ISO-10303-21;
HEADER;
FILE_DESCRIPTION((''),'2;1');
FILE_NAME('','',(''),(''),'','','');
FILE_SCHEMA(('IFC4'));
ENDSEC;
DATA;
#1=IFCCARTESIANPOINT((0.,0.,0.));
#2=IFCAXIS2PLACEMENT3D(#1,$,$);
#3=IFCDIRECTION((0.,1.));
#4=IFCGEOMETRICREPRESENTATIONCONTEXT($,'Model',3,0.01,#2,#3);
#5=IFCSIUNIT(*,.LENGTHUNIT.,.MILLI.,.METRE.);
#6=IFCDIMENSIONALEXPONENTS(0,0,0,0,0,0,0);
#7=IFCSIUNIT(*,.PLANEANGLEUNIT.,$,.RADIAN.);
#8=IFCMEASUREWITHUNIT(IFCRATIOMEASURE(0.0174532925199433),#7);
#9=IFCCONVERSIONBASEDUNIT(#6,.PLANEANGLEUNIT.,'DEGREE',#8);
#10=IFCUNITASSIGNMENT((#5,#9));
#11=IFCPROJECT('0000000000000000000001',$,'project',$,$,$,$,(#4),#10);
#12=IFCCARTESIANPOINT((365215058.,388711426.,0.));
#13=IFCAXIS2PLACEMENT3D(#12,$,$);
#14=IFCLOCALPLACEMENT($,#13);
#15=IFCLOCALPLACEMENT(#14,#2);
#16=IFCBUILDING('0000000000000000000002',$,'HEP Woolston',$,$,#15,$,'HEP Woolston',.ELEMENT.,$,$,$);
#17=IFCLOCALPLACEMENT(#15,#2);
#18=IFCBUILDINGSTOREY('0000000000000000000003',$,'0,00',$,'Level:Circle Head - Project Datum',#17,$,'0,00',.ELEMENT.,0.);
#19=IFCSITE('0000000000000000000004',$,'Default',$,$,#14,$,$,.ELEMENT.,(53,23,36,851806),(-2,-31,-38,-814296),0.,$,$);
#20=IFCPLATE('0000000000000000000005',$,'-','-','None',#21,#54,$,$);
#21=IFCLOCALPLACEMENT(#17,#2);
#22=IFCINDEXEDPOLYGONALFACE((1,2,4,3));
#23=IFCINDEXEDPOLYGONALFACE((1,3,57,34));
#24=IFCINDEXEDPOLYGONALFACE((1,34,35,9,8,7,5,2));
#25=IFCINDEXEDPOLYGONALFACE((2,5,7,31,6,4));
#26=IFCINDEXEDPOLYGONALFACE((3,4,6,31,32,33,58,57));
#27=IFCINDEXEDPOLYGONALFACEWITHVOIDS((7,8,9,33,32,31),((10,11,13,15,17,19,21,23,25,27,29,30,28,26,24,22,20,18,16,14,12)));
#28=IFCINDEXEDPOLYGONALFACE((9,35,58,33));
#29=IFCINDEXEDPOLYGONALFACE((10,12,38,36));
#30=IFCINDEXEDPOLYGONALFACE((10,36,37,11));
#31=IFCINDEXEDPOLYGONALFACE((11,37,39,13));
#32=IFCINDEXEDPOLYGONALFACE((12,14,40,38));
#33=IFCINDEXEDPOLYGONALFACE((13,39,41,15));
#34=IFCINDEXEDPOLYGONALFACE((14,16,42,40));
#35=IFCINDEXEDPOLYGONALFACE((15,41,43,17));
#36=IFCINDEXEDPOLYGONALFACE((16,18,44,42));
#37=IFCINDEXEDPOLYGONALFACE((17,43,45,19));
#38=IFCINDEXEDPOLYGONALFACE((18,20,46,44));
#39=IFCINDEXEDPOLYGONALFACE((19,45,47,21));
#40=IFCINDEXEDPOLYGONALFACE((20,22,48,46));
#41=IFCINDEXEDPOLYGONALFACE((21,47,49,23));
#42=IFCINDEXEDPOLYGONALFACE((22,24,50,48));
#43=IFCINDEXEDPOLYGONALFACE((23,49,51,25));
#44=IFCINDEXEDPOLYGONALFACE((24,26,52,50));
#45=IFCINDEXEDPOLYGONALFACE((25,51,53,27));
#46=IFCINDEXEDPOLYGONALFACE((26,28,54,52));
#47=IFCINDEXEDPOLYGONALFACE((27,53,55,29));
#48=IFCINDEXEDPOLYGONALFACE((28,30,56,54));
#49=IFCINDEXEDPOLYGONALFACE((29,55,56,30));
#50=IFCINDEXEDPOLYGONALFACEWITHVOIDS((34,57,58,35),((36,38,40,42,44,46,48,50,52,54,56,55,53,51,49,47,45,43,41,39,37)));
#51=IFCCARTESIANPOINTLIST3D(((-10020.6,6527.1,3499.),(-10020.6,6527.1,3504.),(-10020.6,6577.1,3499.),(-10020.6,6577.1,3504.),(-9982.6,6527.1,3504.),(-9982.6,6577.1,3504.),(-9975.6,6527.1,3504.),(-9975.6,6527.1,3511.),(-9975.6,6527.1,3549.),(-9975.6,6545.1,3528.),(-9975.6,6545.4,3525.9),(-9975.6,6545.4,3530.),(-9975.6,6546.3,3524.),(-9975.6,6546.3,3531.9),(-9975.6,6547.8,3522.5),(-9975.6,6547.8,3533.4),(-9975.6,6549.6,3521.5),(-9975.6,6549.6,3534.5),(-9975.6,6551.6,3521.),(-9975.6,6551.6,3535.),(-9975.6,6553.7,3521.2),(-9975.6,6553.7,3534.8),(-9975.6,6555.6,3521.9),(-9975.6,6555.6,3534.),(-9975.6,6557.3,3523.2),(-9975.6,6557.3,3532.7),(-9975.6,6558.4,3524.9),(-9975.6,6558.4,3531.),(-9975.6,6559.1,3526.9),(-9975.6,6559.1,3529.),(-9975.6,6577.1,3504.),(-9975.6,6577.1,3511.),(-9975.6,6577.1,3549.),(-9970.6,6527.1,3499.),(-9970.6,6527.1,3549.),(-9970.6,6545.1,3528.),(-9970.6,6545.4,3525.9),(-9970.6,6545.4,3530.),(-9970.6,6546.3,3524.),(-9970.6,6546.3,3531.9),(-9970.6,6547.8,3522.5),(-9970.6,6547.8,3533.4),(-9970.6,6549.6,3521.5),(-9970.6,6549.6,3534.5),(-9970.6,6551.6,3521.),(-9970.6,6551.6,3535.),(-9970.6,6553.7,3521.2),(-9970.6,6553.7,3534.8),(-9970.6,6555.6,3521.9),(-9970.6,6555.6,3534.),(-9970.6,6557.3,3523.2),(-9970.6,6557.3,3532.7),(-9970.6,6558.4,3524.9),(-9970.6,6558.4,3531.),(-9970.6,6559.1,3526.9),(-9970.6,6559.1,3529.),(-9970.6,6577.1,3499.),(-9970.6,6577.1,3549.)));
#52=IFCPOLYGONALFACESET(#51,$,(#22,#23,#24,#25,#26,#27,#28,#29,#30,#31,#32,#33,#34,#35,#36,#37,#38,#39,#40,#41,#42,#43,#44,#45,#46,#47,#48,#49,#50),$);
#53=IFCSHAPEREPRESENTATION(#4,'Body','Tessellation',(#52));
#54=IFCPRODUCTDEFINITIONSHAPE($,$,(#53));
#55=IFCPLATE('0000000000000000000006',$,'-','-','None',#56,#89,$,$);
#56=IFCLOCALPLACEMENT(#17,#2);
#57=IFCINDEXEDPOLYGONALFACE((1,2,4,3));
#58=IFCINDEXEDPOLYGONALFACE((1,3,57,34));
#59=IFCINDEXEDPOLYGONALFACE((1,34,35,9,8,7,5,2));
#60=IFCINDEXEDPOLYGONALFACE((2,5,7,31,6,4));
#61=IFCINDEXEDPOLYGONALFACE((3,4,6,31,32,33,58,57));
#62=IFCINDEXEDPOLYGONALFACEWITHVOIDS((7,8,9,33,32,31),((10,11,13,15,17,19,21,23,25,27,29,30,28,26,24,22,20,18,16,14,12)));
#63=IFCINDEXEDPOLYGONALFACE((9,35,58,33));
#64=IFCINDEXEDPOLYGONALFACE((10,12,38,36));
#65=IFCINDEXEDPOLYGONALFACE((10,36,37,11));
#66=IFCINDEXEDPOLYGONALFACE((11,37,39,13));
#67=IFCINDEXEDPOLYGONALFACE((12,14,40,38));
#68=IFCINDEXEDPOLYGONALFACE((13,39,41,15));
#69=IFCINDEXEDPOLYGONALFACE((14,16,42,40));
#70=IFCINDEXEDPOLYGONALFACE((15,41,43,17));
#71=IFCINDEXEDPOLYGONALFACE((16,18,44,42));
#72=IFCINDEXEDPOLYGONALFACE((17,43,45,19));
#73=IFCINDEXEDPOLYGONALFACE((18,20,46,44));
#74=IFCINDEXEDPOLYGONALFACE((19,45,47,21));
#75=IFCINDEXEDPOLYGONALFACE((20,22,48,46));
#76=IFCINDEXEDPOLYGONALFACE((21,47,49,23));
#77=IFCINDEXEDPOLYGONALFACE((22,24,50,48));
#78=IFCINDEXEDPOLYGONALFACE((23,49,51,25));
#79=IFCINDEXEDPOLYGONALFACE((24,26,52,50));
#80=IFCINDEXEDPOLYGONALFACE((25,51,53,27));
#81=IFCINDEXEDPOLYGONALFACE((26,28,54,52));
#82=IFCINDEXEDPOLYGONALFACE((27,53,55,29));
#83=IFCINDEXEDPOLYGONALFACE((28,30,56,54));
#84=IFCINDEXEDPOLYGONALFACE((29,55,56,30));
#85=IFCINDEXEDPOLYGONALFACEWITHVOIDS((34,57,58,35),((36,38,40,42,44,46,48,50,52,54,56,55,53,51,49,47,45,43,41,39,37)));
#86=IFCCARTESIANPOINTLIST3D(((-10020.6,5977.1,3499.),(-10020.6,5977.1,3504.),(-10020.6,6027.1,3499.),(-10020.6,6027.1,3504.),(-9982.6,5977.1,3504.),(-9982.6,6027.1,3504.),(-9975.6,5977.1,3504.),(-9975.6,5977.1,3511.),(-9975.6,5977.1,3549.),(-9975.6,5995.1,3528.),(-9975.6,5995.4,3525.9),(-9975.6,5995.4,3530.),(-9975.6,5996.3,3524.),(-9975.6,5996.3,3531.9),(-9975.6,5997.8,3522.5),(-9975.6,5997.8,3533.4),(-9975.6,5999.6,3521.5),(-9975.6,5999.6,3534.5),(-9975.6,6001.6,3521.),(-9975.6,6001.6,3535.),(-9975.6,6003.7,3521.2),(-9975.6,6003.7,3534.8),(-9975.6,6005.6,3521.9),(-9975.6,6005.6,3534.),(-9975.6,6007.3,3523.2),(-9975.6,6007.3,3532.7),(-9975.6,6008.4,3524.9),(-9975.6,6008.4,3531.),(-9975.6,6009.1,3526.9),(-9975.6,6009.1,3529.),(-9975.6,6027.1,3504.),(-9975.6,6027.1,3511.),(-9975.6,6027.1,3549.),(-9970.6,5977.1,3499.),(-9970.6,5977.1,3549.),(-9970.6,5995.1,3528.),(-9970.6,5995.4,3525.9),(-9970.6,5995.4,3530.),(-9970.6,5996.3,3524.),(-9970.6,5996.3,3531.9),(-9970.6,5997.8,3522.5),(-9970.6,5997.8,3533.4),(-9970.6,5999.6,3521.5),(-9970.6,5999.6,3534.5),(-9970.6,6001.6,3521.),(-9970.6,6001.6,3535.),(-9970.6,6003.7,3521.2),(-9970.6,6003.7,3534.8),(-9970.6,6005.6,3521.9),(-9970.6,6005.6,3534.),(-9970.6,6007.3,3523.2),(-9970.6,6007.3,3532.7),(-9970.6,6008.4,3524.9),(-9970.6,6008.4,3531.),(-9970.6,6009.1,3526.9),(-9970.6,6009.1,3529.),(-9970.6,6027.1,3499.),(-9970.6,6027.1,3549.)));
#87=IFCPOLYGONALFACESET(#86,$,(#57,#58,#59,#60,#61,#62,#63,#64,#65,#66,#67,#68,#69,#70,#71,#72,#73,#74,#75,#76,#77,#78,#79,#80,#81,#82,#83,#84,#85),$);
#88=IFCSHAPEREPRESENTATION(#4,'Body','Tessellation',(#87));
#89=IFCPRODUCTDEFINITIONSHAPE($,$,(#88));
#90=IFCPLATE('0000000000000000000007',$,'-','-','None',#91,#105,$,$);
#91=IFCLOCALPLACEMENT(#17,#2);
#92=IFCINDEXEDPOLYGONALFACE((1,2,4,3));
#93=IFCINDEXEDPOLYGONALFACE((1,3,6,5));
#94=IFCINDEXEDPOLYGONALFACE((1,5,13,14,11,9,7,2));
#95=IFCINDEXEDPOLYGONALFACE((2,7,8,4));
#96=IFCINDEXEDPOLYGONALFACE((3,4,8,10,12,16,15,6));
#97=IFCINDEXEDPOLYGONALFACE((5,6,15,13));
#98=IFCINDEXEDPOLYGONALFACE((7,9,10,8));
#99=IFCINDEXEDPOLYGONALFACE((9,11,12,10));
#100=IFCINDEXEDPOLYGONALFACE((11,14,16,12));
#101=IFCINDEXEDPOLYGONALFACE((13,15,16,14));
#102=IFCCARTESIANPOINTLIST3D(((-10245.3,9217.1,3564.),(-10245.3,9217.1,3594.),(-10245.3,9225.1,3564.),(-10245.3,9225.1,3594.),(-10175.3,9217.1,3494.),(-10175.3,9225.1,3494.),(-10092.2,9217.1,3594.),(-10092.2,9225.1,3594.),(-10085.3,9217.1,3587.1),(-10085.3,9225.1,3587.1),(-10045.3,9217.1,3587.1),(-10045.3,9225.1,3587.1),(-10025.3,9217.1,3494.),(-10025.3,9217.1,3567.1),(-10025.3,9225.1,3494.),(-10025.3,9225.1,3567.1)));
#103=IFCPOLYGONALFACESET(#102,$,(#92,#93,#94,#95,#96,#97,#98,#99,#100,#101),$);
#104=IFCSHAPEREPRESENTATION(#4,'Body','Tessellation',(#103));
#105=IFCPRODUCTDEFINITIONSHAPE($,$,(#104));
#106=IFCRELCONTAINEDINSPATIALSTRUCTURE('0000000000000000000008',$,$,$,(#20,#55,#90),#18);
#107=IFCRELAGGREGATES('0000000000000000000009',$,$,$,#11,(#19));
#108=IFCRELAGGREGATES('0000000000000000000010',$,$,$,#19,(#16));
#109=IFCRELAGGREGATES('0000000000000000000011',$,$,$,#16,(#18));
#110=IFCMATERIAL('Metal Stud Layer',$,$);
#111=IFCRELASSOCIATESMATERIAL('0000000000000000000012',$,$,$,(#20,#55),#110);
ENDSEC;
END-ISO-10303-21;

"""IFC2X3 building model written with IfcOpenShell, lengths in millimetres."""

from ifc_helpers import new_model, entity, si_unit, converted_unit, point, direction, frame, frame_2d, origin, origin_with_axes, origin_2d_with_axis, place, context, project, spatial, polyline, circle_curve, line_curve, trimmed, segment, composite_curve, circle, outline, extrude, material, element, save


model = new_model("IFC2X3")

# Units and contexts
model_context = context("Model", 3, precision=0.01, world=origin(), true_north=direction((0.0, 1.0)))
ifc_project = project(units=[si_unit("LENGTHUNIT", "METRE", prefix="MILLI"), converted_unit("PLANEANGLEUNIT", "DEGREE", entity("IfcRatioMeasure", 0.0174532925199433), si_unit("PLANEANGLEUNIT", "RADIAN"), dimensions=[0, 0, 0, 0, 0, 0, 0])], contexts=[model_context])

# Site, building, storey
site_placement = place(None, frame((365215058.0, 388711426.0, 0.0)))
site = spatial("IfcSite", under=ifc_project, at=site_placement, Name="Default", CompositionType="ELEMENT", RefLatitude=(53, 23, 36, 851806), RefLongitude=(-2, -31, -38, -814296), RefElevation=0.0)
building_placement = place(site_placement, origin())
building = spatial("IfcBuilding", under=site, at=building_placement, Name="HEP Woolston", LongName="HEP Woolston", CompositionType="ELEMENT")
storey_placement = place(building_placement, origin())
storey = spatial("IfcBuildingStorey", under=building, at=storey_placement, Name="0,00", ObjectType="Level:Circle Head - Project Datum", LongName="0,00", CompositionType="ELEMENT", Elevation=0.0)

# Plates, openings
ifc_material = material(Name="Metal Stud Layer")
plate_1_placement = place(storey_placement, frame((-9970.6, 6527.1, 3499.0), z_axis=(0.0, 1.0, 0.0), x_axis=(-1.0, 0.0, 0.0)))
plate_1 = element("IfcPlate", 1, at=plate_1_placement, inside=storey, material=ifc_material, Name="-", Description="-", ObjectType="None", context=model_context, shape_type="SweptSolid", body=[
    extrude(outline(polyline([(0.0, 0.0), (50.0, 0.0), (50.0, 5.0), (5.0, 5.0), (5.0, 50.0), (0.0, 50.0), (0.0, 0.0)])), origin_with_axes(), (0.0, 0.0, 1.0), 50.0),
])
opening_1_placement = place(plate_1_placement, frame((0.0, 0.0, 0.0), z_axis=(0.0, 0.0, 1.0), x_axis=(1.0, 0.0, 0.0)))
element("IfcOpeningElement", 2, at=opening_1_placement, cuts=plate_1, ObjectType="Opening", context=model_context, shape_type="SweptSolid", body=[
    extrude(outline(composite_curve([segment(trimmed(line_curve((50.0, 5.0), (1.0, 0.0), 3.532613), [point((50.0, 5.0))], [point((46.5, 5.0))], True, "CARTESIAN"), True, "CONTINUOUS"), segment(trimmed(circle_curve(frame_2d((46.5, 1.5), x_axis=(-1.0, 0.0)), 3.5), [point((46.5, 5.0))], [point((50.0, 1.5))], False, "CARTESIAN"), True, "CONTINUOUS"), segment(trimmed(line_curve((50.0, 1.5), (0.0, -1.0), 3.532613), [point((50.0, 1.5))], [point((50.0, 5.0))], True, "CARTESIAN"), True, "CONTINUOUS")], self_intersect="UNKNOWN")), origin(), (0.0, 0.0, 1.0), 50.0),
])
opening_2_placement = place(plate_1_placement, origin_with_axes())
element("IfcOpeningElement", 3, at=opening_2_placement, cuts=plate_1, ObjectType="Opening", context=model_context, shape_type="SweptSolid", body=[
    extrude(outline(composite_curve([segment(trimmed(line_curve((5.0, 5.0), (0.0, -1.0), 7.046301), [point((5.0, 5.0))], [point((5.0, 12.0))], False, "CARTESIAN"), True, "CONTINUOUS"), segment(trimmed(circle_curve(frame_2d((12.0, 12.0), x_axis=(1.0, 0.0)), 7.0), [point((5.0, 12.0))], [point((12.0, 5.0))], True, "CARTESIAN"), True, "CONTINUOUS"), segment(trimmed(line_curve((12.0, 5.0), (1.0, 0.0), 7.046301), [point((12.0, 5.0))], [point((5.0, 5.0))], False, "CARTESIAN"), True, "CONTINUOUS")], self_intersect="UNKNOWN")), origin(), (0.0, 0.0, 1.0), 50.0),
])
opening_3_placement = place(plate_1_placement, frame((0.0, 0.0, 0.0), z_axis=(0.0, 0.0, 1.0), x_axis=(1.0, 0.0, 0.0)))
element("IfcOpeningElement", 4, at=opening_3_placement, cuts=plate_1, ObjectType="Opening", context=model_context, shape_type="SweptSolid", body=[
    extrude(outline(composite_curve([segment(trimmed(line_curve((5.0, 50.0), (1.0, 0.0), 3.4874), [point((5.0, 50.0))], [point((1.5, 50.0))], True, "CARTESIAN"), True, "CONTINUOUS"), segment(trimmed(circle_curve(frame_2d((1.5, 46.5), x_axis=(-1.0, 0.0)), 3.5), [point((1.5, 50.0))], [point((5.0, 46.5))], False, "CARTESIAN"), True, "CONTINUOUS"), segment(trimmed(line_curve((5.0, 46.5), (0.0, -1.0), 3.4874), [point((5.0, 46.5))], [point((5.0, 50.0))], True, "CARTESIAN"), True, "CONTINUOUS")], self_intersect="UNKNOWN")), origin(), (0.0, 0.0, 1.0), 50.0),
])
opening_4_placement = place(plate_1_placement, frame((-0.5, 29.0, 25.0), z_axis=(1.0, 0.0, 0.0), x_axis=(0.0, 0.0, -1.0)))
element("IfcOpeningElement", 5, at=opening_4_placement, cuts=plate_1, ObjectType="Opening", context=model_context, shape_type="SweptSolid", body=[
    extrude(circle(Radius=7.0, at=origin_2d_with_axis()), origin(), (0.0, 0.0, 1.0), 6.0),
])
plate_2_placement = place(storey_placement, frame((-9970.6, 5977.1, 3499.0), z_axis=(0.0, 1.0, 0.0), x_axis=(-1.0, 0.0, 0.0)))
plate_2 = element("IfcPlate", 6, at=plate_2_placement, inside=storey, material=ifc_material, Name="-", Description="-", ObjectType="None", context=model_context, shape_type="SweptSolid", body=[
    extrude(outline(polyline([(0.0, 0.0), (50.0, 0.0), (50.0, 5.0), (5.0, 5.0), (5.0, 50.0), (0.0, 50.0), (0.0, 0.0)])), origin_with_axes(), (0.0, 0.0, 1.0), 50.0),
])
opening_5_placement = place(plate_2_placement, frame((0.0, 0.0, 0.0), z_axis=(0.0, 0.0, 1.0), x_axis=(1.0, 0.0, 0.0)))
element("IfcOpeningElement", 7, at=opening_5_placement, cuts=plate_2, ObjectType="Opening", context=model_context, shape_type="SweptSolid", body=[
    extrude(outline(composite_curve([segment(trimmed(line_curve((50.0, 5.0), (1.0, 0.0), 3.532613), [point((50.0, 5.0))], [point((46.5, 5.0))], True, "CARTESIAN"), True, "CONTINUOUS"), segment(trimmed(circle_curve(frame_2d((46.5, 1.5), x_axis=(-1.0, 0.0)), 3.5), [point((46.5, 5.0))], [point((50.0, 1.5))], False, "CARTESIAN"), True, "CONTINUOUS"), segment(trimmed(line_curve((50.0, 1.5), (0.0, -1.0), 3.532613), [point((50.0, 1.5))], [point((50.0, 5.0))], True, "CARTESIAN"), True, "CONTINUOUS")], self_intersect="UNKNOWN")), origin(), (0.0, 0.0, 1.0), 50.0),
])
opening_6_placement = place(plate_2_placement, origin_with_axes())
element("IfcOpeningElement", 8, at=opening_6_placement, cuts=plate_2, ObjectType="Opening", context=model_context, shape_type="SweptSolid", body=[
    extrude(outline(composite_curve([segment(trimmed(line_curve((5.0, 5.0), (0.0, -1.0), 7.046301), [point((5.0, 5.0))], [point((5.0, 12.0))], False, "CARTESIAN"), True, "CONTINUOUS"), segment(trimmed(circle_curve(frame_2d((12.0, 12.0), x_axis=(1.0, 0.0)), 7.0), [point((5.0, 12.0))], [point((12.0, 5.0))], True, "CARTESIAN"), True, "CONTINUOUS"), segment(trimmed(line_curve((12.0, 5.0), (1.0, 0.0), 7.046301), [point((12.0, 5.0))], [point((5.0, 5.0))], False, "CARTESIAN"), True, "CONTINUOUS")], self_intersect="UNKNOWN")), origin(), (0.0, 0.0, 1.0), 50.0),
])
opening_7_placement = place(plate_2_placement, frame((0.0, 0.0, 0.0), z_axis=(0.0, 0.0, 1.0), x_axis=(1.0, 0.0, 0.0)))
element("IfcOpeningElement", 9, at=opening_7_placement, cuts=plate_2, ObjectType="Opening", context=model_context, shape_type="SweptSolid", body=[
    extrude(outline(composite_curve([segment(trimmed(line_curve((5.0, 50.0), (1.0, 0.0), 3.4874), [point((5.0, 50.0))], [point((1.5, 50.0))], True, "CARTESIAN"), True, "CONTINUOUS"), segment(trimmed(circle_curve(frame_2d((1.5, 46.5), x_axis=(-1.0, 0.0)), 3.5), [point((1.5, 50.0))], [point((5.0, 46.5))], False, "CARTESIAN"), True, "CONTINUOUS"), segment(trimmed(line_curve((5.0, 46.5), (0.0, -1.0), 3.4874), [point((5.0, 46.5))], [point((5.0, 50.0))], True, "CARTESIAN"), True, "CONTINUOUS")], self_intersect="UNKNOWN")), origin(), (0.0, 0.0, 1.0), 50.0),
])
opening_8_placement = place(plate_2_placement, frame((-0.5, 29.0, 25.0), z_axis=(1.0, 0.0, 0.0), x_axis=(0.0, 0.0, -1.0)))
element("IfcOpeningElement", 10, at=opening_8_placement, cuts=plate_2, ObjectType="Opening", context=model_context, shape_type="SweptSolid", body=[
    extrude(circle(Radius=7.0, at=origin_2d_with_axis()), origin(), (0.0, 0.0, 1.0), 6.0),
])

# Plate
plate_3_placement = place(storey_placement, frame((-10025.3, 9217.1, 3567.1), z_axis=(0.0, 1.0, 0.0), x_axis=(-1.0, 0.0, 0.0)))
element("IfcPlate", 11, at=plate_3_placement, inside=storey, Name="-", Description="-", ObjectType="None", context=model_context, shape_type="SweptSolid", body=[
    extrude(outline(polyline([(0.0, 0.0), (0.0, -73.1), (150.0, -73.1), (220.0, -3.1), (220.0, 26.9), (66.9, 26.9), (60.0, 20.0), (20.0, 20.0), (0.0, 0.0)])), origin_with_axes(), (0.0, 0.0, 1.0), 8.0),
])

save(model, "model.ifc")
